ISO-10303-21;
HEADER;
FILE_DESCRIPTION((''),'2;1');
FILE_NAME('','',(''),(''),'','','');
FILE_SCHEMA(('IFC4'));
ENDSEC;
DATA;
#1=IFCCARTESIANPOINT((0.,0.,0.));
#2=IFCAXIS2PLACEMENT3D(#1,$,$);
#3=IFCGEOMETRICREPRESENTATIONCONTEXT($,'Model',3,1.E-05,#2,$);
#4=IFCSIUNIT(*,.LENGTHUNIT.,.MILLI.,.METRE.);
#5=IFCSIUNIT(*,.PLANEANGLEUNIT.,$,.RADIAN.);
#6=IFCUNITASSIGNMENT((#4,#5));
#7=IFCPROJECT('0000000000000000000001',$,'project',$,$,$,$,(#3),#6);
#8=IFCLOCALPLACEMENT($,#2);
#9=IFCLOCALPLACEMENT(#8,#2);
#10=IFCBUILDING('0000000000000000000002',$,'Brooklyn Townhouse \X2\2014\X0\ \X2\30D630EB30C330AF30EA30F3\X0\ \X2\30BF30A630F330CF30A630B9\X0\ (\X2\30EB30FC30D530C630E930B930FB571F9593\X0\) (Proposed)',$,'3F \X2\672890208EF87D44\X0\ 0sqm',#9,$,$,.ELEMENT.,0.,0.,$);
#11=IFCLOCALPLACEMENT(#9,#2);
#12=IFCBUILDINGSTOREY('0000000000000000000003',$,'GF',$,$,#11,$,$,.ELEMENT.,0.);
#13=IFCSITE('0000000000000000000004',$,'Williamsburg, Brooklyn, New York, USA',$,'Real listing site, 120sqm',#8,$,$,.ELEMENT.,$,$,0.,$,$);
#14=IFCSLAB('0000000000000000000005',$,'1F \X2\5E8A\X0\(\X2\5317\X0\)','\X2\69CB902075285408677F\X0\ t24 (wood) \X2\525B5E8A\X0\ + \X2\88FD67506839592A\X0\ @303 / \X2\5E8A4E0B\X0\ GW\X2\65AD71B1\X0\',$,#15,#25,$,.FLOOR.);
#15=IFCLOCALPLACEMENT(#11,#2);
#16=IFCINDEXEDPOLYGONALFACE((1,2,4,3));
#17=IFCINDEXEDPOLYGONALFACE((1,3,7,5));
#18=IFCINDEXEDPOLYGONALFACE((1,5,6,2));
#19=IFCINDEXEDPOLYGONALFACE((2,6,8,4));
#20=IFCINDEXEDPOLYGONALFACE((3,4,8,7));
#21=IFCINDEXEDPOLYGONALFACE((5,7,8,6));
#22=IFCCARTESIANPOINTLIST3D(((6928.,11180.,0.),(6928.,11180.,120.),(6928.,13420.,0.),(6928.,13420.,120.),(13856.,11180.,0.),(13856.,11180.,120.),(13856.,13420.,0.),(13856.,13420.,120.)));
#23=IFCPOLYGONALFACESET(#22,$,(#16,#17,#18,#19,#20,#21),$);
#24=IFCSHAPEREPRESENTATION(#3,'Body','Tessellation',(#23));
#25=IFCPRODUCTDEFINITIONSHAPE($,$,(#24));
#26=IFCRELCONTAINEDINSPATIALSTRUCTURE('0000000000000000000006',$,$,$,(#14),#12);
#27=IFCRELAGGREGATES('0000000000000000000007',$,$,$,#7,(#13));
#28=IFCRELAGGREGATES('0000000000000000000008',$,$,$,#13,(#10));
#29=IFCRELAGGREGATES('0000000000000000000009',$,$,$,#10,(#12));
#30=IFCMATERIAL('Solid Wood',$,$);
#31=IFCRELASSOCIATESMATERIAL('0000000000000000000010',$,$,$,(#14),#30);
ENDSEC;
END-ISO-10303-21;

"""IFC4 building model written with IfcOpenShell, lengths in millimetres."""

from ifc_helpers import new_model, si_unit, frame, frame_2d, origin, place, context, project, spatial, rectangle, extrude, material, element, save


model = new_model("IFC4")

# Units and contexts
model_context = context("Model", 3, precision=1e-05, world=origin())
ifc_project = project(units=[si_unit("LENGTHUNIT", "METRE", prefix="MILLI"), si_unit("PLANEANGLEUNIT", "RADIAN")], contexts=[model_context])

# Site, building, storey
site_placement = place(None, origin())
site = spatial("IfcSite", under=ifc_project, at=site_placement, Name="Williamsburg, Brooklyn, New York, USA", ObjectType="Real listing site, 120sqm", CompositionType="ELEMENT", RefElevation=0.0)
building_placement = place(site_placement, origin())
building = spatial("IfcBuilding", under=site, at=building_placement, Name="Brooklyn Townhouse — ブルックリン タウンハウス (ルーフテラス・土間) (Proposed)", ObjectType="3F 木造軸組 0sqm", CompositionType="ELEMENT", ElevationOfRefHeight=0.0, ElevationOfTerrain=0.0)
storey_placement = place(building_placement, origin())
storey = spatial("IfcBuildingStorey", under=building, at=storey_placement, Name="GF", CompositionType="ELEMENT", Elevation=0.0)

# Slab
ifc_material_1 = material(Name="Solid Wood")
slab_1_placement = place(storey_placement, frame((3464.0, 5590.0, 0.0)))
element("IfcSlab", 1, at=slab_1_placement, inside=storey, material=ifc_material_1, Name="1F 床(北)", Description="構造用合板 t24 (wood) 剛床 + 製材根太 @303 / 床下 GW断熱", PredefinedType="FLOOR", context=model_context, shape_type="SweptSolid", body=[
    extrude(rectangle(XDim=6928.0, YDim=2240.0, at=frame_2d((3464.0, 1120.0))), frame((3464.0, 5590.0, 0.0)), (0.0, 0.0, 1.0), 120.0),
])

save(model, "model.ifc")
